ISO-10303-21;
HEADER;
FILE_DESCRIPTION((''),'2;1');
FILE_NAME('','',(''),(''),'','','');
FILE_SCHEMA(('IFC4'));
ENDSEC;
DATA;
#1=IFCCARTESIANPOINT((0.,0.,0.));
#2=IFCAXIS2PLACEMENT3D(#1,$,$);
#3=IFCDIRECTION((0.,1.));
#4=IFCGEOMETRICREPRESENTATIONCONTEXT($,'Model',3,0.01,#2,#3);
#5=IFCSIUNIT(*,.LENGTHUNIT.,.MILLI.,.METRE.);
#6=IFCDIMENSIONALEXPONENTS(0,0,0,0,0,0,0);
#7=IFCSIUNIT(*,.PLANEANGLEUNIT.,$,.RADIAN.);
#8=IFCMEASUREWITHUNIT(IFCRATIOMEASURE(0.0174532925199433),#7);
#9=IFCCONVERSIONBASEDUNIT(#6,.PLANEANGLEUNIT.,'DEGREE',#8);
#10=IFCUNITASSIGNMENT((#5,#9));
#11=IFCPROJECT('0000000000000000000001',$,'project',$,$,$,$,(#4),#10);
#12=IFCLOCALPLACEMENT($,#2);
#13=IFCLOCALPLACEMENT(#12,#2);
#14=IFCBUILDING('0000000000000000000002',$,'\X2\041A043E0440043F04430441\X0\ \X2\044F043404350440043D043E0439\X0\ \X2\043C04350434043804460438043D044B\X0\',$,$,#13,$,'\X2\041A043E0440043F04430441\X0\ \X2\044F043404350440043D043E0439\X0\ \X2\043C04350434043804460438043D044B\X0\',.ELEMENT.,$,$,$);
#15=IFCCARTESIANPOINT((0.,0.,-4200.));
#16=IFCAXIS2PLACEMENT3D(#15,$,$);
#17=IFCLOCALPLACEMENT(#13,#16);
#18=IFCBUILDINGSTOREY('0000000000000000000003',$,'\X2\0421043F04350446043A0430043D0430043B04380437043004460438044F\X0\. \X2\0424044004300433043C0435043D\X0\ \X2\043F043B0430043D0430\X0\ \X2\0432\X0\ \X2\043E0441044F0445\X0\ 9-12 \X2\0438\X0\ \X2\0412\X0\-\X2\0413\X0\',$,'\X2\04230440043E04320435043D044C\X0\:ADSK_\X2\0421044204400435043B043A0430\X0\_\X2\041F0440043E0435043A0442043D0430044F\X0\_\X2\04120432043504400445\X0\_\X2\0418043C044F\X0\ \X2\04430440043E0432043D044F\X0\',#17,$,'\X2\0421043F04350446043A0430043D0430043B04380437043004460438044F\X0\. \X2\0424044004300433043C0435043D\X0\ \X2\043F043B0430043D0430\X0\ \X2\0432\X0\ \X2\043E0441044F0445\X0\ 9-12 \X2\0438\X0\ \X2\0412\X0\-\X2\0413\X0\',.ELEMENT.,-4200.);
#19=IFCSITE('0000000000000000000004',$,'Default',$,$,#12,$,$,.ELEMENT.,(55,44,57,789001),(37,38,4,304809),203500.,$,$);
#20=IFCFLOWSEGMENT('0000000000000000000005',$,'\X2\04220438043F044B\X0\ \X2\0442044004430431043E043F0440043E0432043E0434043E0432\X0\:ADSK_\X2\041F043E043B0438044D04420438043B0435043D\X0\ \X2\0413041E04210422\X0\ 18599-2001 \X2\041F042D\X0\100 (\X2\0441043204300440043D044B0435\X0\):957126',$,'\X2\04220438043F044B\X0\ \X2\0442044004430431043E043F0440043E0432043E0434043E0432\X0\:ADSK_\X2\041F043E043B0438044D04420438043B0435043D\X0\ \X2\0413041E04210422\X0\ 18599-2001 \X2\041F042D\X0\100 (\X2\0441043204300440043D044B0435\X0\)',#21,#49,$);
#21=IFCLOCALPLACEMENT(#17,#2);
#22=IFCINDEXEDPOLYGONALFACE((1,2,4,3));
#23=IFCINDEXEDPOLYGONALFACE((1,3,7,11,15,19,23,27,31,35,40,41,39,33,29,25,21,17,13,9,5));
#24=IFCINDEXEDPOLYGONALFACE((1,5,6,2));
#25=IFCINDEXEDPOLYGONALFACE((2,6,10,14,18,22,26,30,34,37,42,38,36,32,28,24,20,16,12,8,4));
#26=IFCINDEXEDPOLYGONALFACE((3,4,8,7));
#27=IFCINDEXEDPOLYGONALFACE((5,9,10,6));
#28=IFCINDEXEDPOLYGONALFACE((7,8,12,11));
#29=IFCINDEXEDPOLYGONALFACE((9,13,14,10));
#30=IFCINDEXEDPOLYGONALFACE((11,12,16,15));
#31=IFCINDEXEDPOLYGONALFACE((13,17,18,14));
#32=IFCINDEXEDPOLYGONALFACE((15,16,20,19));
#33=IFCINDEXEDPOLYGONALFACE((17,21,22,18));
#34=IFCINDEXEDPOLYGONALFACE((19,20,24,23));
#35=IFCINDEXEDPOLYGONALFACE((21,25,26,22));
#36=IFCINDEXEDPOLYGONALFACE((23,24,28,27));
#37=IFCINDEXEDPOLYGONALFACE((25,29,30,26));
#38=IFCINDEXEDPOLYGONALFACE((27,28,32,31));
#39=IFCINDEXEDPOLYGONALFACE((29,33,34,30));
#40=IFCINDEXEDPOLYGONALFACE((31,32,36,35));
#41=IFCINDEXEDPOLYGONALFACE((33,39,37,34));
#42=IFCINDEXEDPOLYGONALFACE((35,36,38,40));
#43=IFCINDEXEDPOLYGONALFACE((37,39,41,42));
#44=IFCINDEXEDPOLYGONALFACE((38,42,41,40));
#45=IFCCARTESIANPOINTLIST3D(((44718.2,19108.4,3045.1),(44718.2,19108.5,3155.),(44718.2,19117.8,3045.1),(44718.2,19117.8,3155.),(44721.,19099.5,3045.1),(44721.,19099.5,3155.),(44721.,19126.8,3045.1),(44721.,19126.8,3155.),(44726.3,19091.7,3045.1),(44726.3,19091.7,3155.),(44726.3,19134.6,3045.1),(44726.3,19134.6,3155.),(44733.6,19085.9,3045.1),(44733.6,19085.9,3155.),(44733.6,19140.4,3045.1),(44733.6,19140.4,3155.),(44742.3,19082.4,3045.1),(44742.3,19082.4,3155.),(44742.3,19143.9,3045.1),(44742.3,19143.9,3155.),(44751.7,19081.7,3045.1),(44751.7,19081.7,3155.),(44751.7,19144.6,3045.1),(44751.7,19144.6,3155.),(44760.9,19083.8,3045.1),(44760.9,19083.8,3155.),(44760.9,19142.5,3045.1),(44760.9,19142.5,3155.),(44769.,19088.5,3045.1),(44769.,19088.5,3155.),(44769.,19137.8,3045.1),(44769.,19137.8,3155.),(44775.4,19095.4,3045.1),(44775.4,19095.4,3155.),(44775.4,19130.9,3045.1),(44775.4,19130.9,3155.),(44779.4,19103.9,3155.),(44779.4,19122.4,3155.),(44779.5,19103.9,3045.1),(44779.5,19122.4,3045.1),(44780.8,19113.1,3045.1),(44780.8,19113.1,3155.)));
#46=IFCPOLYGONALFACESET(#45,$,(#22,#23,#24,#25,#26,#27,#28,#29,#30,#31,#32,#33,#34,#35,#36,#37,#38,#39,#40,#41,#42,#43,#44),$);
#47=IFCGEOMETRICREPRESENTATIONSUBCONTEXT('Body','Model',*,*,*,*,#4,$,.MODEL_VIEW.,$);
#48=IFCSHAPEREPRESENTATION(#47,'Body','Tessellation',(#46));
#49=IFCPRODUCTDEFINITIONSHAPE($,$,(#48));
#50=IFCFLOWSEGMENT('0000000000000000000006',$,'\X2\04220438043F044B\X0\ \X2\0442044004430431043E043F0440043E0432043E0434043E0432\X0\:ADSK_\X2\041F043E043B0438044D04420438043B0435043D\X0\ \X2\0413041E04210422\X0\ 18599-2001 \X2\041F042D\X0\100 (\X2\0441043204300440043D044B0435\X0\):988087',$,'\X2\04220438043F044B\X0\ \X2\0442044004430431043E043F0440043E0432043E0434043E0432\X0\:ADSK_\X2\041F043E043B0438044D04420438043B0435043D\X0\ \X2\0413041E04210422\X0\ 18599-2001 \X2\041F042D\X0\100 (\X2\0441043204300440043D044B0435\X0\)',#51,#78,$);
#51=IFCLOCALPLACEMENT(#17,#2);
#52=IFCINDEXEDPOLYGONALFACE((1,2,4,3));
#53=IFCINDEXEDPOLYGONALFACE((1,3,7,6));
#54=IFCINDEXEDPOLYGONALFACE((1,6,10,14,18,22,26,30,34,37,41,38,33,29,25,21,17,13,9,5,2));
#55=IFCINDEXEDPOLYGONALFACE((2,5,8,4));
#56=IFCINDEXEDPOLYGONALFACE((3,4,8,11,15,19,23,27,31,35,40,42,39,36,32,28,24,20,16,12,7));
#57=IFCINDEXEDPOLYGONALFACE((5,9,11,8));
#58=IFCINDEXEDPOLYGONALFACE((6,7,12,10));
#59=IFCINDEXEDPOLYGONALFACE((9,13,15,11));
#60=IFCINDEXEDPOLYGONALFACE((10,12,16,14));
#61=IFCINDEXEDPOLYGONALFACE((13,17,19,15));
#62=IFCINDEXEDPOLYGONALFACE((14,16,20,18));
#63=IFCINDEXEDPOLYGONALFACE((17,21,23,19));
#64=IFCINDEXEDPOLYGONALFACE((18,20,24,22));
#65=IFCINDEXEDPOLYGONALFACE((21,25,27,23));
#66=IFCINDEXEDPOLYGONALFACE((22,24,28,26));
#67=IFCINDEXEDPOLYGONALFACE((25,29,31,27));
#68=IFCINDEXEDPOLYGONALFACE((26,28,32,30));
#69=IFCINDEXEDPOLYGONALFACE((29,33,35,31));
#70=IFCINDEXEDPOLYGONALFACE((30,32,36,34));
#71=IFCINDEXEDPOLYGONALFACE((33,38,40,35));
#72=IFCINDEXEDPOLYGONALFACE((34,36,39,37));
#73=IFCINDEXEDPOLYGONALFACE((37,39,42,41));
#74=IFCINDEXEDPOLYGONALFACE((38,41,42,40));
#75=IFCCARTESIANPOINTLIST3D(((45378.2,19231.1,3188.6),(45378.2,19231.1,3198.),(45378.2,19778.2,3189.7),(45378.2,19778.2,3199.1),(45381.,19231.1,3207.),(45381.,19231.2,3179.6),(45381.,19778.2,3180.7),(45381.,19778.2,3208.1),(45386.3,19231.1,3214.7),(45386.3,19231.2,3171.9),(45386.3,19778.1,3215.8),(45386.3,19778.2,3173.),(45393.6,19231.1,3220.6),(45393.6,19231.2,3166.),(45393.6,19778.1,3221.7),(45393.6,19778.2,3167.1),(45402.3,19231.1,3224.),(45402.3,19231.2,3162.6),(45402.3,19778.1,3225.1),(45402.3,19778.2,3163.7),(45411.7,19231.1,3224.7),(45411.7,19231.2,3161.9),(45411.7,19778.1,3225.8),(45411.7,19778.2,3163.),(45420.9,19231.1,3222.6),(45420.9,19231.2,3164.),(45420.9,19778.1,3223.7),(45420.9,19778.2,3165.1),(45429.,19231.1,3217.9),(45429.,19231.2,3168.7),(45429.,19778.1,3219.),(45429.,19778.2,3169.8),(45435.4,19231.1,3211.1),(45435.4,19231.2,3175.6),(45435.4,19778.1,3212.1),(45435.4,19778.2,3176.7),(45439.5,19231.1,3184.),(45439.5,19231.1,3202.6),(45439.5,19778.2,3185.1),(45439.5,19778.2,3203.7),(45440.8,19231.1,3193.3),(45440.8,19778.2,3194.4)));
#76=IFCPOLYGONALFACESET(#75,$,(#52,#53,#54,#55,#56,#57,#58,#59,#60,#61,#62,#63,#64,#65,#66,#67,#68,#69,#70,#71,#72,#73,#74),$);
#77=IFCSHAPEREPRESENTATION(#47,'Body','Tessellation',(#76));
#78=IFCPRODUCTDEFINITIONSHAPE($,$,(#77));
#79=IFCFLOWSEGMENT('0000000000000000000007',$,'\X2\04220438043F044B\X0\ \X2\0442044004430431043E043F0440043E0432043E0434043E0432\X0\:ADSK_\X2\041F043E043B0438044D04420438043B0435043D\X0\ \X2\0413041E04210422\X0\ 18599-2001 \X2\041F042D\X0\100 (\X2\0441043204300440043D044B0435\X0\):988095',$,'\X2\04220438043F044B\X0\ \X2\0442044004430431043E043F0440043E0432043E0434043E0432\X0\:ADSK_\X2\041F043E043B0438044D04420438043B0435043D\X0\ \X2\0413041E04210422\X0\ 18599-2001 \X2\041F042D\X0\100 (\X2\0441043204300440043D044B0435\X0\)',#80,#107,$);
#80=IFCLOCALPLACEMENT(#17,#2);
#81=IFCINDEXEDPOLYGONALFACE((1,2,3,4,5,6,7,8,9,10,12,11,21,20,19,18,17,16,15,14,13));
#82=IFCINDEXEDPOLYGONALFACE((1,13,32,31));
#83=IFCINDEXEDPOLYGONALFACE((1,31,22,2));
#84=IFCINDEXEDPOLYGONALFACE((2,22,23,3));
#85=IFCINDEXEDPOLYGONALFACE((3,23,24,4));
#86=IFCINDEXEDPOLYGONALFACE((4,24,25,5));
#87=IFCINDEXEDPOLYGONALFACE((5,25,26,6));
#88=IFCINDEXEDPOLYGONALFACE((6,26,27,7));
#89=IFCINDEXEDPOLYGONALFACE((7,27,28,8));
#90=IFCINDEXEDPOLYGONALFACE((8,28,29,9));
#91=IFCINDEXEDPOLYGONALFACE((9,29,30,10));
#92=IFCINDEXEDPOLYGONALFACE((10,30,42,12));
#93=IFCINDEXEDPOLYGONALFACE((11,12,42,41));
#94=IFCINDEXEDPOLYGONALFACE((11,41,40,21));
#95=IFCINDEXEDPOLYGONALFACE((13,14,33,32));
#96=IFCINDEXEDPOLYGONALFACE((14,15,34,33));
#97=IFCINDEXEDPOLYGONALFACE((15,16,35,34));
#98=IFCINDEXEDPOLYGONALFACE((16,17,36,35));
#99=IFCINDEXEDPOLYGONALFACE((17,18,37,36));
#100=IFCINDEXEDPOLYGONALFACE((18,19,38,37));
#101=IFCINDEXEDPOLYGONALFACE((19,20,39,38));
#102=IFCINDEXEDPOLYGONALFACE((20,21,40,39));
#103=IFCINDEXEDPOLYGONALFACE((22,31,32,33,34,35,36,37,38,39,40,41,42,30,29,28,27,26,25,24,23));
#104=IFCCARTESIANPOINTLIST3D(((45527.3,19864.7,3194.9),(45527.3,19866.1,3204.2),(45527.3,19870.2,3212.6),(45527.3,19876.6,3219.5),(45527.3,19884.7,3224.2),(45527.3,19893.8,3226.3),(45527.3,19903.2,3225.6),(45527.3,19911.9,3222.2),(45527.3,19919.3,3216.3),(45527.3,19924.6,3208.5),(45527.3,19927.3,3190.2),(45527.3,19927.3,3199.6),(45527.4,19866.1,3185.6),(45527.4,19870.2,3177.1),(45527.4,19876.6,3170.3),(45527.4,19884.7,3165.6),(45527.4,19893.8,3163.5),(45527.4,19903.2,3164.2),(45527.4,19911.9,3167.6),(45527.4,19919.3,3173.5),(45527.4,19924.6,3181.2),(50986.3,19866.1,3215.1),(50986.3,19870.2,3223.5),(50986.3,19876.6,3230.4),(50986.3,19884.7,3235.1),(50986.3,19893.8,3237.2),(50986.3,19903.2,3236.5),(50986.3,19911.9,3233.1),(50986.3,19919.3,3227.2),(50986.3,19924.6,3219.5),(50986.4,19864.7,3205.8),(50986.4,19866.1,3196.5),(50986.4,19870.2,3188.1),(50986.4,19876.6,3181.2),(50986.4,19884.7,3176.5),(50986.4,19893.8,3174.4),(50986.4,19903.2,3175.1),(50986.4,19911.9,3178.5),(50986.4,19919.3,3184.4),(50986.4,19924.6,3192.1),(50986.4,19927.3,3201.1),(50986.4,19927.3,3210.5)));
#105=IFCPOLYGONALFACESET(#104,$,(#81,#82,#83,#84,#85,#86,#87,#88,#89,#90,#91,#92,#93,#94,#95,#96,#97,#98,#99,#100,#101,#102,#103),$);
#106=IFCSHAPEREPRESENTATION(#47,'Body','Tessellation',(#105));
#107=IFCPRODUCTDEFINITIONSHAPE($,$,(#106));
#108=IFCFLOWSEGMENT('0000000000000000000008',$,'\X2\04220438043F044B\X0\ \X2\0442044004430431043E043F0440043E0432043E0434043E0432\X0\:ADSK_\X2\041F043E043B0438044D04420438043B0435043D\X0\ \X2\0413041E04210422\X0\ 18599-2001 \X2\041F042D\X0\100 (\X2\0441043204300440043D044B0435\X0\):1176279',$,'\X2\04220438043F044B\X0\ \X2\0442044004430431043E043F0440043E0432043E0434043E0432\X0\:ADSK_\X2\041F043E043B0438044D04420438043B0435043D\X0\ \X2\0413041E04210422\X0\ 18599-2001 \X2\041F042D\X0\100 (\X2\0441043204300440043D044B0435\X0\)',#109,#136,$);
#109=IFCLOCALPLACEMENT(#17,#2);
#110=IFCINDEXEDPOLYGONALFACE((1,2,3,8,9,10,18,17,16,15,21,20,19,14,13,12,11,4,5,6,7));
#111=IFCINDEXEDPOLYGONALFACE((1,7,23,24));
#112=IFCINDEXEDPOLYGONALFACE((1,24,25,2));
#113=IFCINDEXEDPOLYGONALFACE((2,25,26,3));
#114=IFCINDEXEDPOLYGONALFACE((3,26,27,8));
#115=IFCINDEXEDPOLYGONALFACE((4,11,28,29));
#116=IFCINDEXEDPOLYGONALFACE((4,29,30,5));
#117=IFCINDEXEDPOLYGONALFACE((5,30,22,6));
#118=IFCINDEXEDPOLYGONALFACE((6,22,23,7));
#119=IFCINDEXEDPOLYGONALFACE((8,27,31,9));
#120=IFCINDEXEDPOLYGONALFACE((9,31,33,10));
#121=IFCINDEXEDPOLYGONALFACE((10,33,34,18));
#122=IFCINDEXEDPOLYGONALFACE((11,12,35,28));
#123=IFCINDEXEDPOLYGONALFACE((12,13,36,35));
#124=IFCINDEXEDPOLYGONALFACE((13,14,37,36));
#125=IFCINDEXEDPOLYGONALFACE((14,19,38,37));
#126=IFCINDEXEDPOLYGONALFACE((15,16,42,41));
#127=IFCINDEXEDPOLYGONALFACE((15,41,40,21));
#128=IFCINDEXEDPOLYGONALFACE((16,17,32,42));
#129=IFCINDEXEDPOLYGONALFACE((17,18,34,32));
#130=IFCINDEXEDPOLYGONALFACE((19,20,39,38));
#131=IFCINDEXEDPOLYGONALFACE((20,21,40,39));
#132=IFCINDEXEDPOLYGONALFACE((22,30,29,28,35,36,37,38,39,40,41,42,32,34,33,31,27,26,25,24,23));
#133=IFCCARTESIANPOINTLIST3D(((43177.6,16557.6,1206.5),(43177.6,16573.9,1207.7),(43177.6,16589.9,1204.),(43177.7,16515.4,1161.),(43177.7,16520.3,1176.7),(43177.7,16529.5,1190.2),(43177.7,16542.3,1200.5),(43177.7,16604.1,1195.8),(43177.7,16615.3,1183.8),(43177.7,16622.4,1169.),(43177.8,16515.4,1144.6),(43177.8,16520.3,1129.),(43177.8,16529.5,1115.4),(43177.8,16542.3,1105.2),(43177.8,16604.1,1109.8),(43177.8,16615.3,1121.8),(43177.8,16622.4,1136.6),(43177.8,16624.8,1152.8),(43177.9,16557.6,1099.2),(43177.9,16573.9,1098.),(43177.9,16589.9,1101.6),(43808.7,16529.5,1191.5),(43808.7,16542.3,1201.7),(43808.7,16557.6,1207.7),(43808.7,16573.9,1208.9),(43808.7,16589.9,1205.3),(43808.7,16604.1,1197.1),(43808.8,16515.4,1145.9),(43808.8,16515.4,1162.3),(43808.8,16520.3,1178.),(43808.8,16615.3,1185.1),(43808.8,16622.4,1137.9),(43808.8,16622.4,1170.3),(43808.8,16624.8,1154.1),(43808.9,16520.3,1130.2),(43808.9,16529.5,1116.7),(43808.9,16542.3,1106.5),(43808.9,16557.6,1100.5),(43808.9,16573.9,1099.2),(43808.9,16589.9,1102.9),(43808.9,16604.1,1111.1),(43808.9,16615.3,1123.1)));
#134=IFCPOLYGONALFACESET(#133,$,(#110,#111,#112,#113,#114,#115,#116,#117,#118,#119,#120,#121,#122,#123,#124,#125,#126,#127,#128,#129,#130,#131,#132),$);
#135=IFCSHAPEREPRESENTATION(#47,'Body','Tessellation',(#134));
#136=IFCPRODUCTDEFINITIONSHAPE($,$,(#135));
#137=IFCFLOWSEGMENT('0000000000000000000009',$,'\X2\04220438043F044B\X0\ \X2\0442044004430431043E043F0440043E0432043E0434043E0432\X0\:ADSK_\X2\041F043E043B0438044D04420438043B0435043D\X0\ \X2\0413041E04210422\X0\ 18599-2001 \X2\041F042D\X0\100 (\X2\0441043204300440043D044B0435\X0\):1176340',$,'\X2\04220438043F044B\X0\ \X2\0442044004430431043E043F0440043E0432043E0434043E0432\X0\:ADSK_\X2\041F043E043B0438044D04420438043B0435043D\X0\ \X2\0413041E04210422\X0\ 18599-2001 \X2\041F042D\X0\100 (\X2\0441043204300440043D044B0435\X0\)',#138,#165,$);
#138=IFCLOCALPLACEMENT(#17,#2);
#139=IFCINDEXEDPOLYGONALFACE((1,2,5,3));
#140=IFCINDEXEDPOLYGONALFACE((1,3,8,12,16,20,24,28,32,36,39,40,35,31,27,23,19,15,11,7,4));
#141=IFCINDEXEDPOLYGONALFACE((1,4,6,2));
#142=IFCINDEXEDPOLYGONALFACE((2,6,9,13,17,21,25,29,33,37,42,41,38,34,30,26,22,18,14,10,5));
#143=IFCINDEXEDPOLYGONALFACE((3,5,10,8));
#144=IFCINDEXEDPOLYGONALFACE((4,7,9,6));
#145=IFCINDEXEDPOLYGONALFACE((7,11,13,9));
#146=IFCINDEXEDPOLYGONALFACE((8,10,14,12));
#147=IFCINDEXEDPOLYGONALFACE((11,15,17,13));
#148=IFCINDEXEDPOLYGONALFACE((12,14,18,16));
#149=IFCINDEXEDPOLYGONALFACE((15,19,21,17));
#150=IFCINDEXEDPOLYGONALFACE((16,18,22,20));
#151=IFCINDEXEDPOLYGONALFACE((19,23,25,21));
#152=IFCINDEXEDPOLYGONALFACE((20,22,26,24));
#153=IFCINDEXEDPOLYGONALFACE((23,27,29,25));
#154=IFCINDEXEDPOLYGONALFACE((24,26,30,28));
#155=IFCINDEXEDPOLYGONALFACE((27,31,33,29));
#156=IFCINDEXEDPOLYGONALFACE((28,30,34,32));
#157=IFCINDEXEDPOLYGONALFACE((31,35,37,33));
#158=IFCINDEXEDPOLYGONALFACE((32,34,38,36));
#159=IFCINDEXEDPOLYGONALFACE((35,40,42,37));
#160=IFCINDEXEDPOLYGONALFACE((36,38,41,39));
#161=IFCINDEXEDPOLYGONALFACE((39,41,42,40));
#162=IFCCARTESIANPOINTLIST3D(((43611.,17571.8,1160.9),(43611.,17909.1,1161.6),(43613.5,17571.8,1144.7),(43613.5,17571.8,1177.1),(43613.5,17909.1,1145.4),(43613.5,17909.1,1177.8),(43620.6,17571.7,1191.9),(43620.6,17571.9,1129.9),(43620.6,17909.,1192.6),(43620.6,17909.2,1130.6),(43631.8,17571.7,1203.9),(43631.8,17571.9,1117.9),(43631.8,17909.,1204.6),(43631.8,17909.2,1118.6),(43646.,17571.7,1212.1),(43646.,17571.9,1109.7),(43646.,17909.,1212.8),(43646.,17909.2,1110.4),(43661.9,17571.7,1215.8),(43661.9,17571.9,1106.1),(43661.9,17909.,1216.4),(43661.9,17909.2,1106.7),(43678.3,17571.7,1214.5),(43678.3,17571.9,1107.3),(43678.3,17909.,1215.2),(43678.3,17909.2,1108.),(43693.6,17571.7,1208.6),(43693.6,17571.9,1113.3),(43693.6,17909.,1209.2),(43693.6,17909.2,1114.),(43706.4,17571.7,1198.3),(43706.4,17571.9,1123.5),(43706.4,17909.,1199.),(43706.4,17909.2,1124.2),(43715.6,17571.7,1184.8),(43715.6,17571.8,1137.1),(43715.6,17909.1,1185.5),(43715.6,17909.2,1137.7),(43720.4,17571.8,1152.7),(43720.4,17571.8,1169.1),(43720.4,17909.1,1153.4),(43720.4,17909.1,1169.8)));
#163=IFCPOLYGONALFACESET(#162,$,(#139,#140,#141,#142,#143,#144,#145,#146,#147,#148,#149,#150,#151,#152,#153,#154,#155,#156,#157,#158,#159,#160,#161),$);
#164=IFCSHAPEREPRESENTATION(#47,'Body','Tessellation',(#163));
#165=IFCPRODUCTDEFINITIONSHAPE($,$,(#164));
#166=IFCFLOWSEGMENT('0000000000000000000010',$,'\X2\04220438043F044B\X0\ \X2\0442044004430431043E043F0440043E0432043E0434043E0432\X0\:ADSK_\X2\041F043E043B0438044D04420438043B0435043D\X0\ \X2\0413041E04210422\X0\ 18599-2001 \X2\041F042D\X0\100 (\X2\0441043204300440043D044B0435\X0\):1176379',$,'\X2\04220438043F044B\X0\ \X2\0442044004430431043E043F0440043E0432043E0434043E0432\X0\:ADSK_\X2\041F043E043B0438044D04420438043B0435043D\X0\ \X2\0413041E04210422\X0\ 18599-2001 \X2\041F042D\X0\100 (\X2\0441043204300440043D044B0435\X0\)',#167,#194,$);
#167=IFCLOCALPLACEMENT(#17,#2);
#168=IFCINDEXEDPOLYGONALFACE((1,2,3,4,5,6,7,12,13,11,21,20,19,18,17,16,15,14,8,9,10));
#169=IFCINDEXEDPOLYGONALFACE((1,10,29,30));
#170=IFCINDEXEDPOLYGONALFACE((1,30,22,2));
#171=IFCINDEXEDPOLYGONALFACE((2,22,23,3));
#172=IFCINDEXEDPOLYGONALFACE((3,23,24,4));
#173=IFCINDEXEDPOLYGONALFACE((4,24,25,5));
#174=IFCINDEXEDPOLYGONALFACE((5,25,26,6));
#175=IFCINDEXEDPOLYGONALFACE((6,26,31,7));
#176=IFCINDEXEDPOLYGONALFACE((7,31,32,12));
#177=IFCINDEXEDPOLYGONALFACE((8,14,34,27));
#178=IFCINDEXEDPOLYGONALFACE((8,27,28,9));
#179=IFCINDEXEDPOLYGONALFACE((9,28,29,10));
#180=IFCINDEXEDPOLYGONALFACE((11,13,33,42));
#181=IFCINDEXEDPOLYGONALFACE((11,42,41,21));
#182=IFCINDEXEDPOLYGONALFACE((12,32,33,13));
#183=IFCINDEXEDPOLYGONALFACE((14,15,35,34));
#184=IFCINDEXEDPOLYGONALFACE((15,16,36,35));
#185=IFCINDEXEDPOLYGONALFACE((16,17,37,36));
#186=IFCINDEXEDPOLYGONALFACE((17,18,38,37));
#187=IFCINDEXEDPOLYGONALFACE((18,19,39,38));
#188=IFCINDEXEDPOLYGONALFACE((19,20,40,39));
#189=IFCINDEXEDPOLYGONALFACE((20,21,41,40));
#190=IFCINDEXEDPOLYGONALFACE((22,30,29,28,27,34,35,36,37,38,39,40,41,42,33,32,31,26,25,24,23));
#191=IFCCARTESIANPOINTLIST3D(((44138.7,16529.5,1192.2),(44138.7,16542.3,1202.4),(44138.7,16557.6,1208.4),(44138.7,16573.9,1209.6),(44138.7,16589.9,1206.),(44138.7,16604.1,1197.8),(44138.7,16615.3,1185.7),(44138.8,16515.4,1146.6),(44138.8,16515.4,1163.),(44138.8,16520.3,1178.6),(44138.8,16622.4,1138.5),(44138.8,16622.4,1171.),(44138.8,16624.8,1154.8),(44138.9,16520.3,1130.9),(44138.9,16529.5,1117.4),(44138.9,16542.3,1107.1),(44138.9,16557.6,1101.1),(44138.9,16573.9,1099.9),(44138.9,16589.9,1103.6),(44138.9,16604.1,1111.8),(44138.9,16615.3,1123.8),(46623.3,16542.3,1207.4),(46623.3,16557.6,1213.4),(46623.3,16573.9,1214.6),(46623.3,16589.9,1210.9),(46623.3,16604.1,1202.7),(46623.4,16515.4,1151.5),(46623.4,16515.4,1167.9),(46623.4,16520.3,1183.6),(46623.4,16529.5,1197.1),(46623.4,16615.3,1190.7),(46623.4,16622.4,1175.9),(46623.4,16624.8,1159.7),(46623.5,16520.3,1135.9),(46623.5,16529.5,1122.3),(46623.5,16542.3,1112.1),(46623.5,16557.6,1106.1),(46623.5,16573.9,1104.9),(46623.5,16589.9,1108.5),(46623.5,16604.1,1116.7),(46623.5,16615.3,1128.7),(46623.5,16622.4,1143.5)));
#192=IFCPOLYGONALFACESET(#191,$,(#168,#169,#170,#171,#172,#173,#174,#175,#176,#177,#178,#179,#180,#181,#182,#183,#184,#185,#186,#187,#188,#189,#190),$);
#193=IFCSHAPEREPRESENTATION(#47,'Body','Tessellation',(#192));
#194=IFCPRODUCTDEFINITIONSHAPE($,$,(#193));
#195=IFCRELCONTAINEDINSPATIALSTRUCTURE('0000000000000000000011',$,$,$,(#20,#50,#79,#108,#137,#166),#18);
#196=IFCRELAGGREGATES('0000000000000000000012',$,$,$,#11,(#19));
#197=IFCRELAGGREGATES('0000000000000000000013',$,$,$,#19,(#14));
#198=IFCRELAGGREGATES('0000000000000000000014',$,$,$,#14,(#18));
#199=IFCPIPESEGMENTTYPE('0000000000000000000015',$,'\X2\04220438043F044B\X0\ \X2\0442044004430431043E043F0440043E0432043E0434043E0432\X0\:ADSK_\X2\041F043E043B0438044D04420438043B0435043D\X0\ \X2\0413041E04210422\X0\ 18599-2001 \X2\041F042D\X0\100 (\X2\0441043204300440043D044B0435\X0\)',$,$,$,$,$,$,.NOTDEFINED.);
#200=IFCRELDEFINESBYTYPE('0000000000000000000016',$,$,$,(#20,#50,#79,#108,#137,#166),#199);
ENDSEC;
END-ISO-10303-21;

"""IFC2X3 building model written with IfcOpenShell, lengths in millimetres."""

from ifc_helpers import new_model, entity, si_unit, converted_unit, direction, frame, origin, origin_2d_with_axis, place, context, subcontext, project, spatial, circle, extrude, type_object, element, save


model = new_model("IFC2X3")

# Units and contexts
model_context = context("Model", 3, precision=0.01, world=origin(), true_north=direction((0.0, 1.0)))
body_context = subcontext(model_context, "Body", "Model", "MODEL_VIEW")
ifc_project = project(units=[si_unit("LENGTHUNIT", "METRE", prefix="MILLI"), converted_unit("PLANEANGLEUNIT", "DEGREE", entity("IfcRatioMeasure", 0.0174532925199433), si_unit("PLANEANGLEUNIT", "RADIAN"), dimensions=[0, 0, 0, 0, 0, 0, 0])], contexts=[model_context])

# Site, building, storey
site_placement = place(None, origin())
site = spatial("IfcSite", under=ifc_project, at=site_placement, Name="Default", CompositionType="ELEMENT", RefLatitude=(55, 44, 57, 789001), RefLongitude=(37, 38, 4, 304809), RefElevation=203500.0)
building_placement = place(site_placement, origin())
building = spatial("IfcBuilding", under=site, at=building_placement, Name="Корпус ядерной медицины", LongName="Корпус ядерной медицины", CompositionType="ELEMENT")
storey_placement = place(building_placement, frame((0.0, 0.0, -4200.0)))
storey = spatial("IfcBuildingStorey", under=building, at=storey_placement, Name="Спецканализация. Фрагмен плана в осях 9-12 и В-Г", ObjectType="Уровень:ADSK_Стрелка_Проектная_Вверх_Имя уровня", LongName="Спецканализация. Фрагмен плана в осях 9-12 и В-Г", CompositionType="ELEMENT", Elevation=-4200.0)

# Flow segments
pipe_segment_type = type_object("IfcPipeSegmentType", Name="Типы трубопроводов:ADSK_Полиэтилен ГОСТ 18599-2001 ПЭ100 (сварные)", PredefinedType="NOTDEFINED")
flow_segment_1_placement = place(storey_placement, frame((44716.2, 19080.0, 3045.1)))
element("IfcFlowSegment", 1, at=flow_segment_1_placement, inside=storey, type_object=pipe_segment_type, Name="Типы трубопроводов:ADSK_Полиэтилен ГОСТ 18599-2001 ПЭ100 (сварные):957126", ObjectType="Типы трубопроводов:ADSK_Полиэтилен ГОСТ 18599-2001 ПЭ100 (сварные)", context=body_context, shape_type="SweptSolid", body=[
    extrude(circle(Radius=31.5, at=origin_2d_with_axis()), frame((33.1, 33.1, 0.0), z_axis=(-0.000025, 0.000071, 1.0), x_axis=(1.0, 0.0, 0.000025)), (0.0, 0.0, 1.0), 109.9),
])
flow_segment_2_placement = place(storey_placement, frame((45376.2, 19231.1, 3160.2)))
element("IfcFlowSegment", 2, at=flow_segment_2_placement, inside=storey, type_object=pipe_segment_type, Name="Типы трубопроводов:ADSK_Полиэтилен ГОСТ 18599-2001 ПЭ100 (сварные):988087", ObjectType="Типы трубопроводов:ADSK_Полиэтилен ГОСТ 18599-2001 ПЭ100 (сварные)", context=body_context, shape_type="SweptSolid", body=[
    extrude(circle(Radius=31.5, at=origin_2d_with_axis()), frame((33.1, 0.1, 33.1), z_axis=(0.0, 0.999998, 0.002), x_axis=(1.0, 0.0, 0.0)), (0.0, 0.0, 1.0), 547.1),
])
flow_segment_3_placement = place(storey_placement, frame((45527.3, 19863.1, 3161.8)))
element("IfcFlowSegment", 3, at=flow_segment_3_placement, inside=storey, type_object=pipe_segment_type, Name="Типы трубопроводов:ADSK_Полиэтилен ГОСТ 18599-2001 ПЭ100 (сварные):988095", ObjectType="Типы трубопроводов:ADSK_Полиэтилен ГОСТ 18599-2001 ПЭ100 (сварные)", context=body_context, shape_type="SweptSolid", body=[
    extrude(circle(Radius=31.5, at=origin_2d_with_axis()), frame((0.1, 33.1, 33.1), z_axis=(0.999998, 0.0, 0.002), x_axis=(0.0, -1.0, 0.0)), (0.0, 0.0, 1.0), 5459.0),
])
flow_segment_4_placement = place(storey_placement, frame((43177.6, 16513.2, 1096.2)))
element("IfcFlowSegment", 4, at=flow_segment_4_placement, inside=storey, type_object=pipe_segment_type, Name="Типы трубопроводов:ADSK_Полиэтилен ГОСТ 18599-2001 ПЭ100 (сварные):1176279", ObjectType="Типы трубопроводов:ADSK_Полиэтилен ГОСТ 18599-2001 ПЭ100 (сварные)", context=body_context, shape_type="SweptSolid", body=[
    extrude(circle(Radius=55.0, at=origin_2d_with_axis()), frame((0.1, 56.6, 56.6), z_axis=(0.999998, 0.0, 0.002), x_axis=(0.0, 1.0, 0.0)), (0.0, 0.0, 1.0), 631.1),
])
flow_segment_5_placement = place(storey_placement, frame((43609.4, 17571.7, 1104.3)))
element("IfcFlowSegment", 5, at=flow_segment_5_placement, inside=storey, type_object=pipe_segment_type, Name="Типы трубопроводов:ADSK_Полиэтилен ГОСТ 18599-2001 ПЭ100 (сварные):1176340", ObjectType="Типы трубопроводов:ADSK_Полиэтилен ГОСТ 18599-2001 ПЭ100 (сварные)", context=body_context, shape_type="SweptSolid", body=[
    extrude(circle(Radius=55.0, at=origin_2d_with_axis()), frame((56.6, 0.1, 56.6), z_axis=(0.0, 0.999998, 0.002), x_axis=(-1.0, 0.0, 0.0)), (0.0, 0.0, 1.0), 337.3),
])
flow_segment_6_placement = place(storey_placement, frame((44138.7, 16513.2, 1098.2)))
element("IfcFlowSegment", 6, at=flow_segment_6_placement, inside=storey, type_object=pipe_segment_type, Name="Типы трубопроводов:ADSK_Полиэтилен ГОСТ 18599-2001 ПЭ100 (сварные):1176379", ObjectType="Типы трубопроводов:ADSK_Полиэтилен ГОСТ 18599-2001 ПЭ100 (сварные)", context=body_context, shape_type="SweptSolid", body=[
    extrude(circle(Radius=55.0, at=origin_2d_with_axis()), frame((0.1, 56.6, 56.6), z_axis=(0.999998, 0.0, 0.002), x_axis=(0.0, 1.0, 0.0)), (0.0, 0.0, 1.0), 2484.6),
])

save(model, "model.ifc")
